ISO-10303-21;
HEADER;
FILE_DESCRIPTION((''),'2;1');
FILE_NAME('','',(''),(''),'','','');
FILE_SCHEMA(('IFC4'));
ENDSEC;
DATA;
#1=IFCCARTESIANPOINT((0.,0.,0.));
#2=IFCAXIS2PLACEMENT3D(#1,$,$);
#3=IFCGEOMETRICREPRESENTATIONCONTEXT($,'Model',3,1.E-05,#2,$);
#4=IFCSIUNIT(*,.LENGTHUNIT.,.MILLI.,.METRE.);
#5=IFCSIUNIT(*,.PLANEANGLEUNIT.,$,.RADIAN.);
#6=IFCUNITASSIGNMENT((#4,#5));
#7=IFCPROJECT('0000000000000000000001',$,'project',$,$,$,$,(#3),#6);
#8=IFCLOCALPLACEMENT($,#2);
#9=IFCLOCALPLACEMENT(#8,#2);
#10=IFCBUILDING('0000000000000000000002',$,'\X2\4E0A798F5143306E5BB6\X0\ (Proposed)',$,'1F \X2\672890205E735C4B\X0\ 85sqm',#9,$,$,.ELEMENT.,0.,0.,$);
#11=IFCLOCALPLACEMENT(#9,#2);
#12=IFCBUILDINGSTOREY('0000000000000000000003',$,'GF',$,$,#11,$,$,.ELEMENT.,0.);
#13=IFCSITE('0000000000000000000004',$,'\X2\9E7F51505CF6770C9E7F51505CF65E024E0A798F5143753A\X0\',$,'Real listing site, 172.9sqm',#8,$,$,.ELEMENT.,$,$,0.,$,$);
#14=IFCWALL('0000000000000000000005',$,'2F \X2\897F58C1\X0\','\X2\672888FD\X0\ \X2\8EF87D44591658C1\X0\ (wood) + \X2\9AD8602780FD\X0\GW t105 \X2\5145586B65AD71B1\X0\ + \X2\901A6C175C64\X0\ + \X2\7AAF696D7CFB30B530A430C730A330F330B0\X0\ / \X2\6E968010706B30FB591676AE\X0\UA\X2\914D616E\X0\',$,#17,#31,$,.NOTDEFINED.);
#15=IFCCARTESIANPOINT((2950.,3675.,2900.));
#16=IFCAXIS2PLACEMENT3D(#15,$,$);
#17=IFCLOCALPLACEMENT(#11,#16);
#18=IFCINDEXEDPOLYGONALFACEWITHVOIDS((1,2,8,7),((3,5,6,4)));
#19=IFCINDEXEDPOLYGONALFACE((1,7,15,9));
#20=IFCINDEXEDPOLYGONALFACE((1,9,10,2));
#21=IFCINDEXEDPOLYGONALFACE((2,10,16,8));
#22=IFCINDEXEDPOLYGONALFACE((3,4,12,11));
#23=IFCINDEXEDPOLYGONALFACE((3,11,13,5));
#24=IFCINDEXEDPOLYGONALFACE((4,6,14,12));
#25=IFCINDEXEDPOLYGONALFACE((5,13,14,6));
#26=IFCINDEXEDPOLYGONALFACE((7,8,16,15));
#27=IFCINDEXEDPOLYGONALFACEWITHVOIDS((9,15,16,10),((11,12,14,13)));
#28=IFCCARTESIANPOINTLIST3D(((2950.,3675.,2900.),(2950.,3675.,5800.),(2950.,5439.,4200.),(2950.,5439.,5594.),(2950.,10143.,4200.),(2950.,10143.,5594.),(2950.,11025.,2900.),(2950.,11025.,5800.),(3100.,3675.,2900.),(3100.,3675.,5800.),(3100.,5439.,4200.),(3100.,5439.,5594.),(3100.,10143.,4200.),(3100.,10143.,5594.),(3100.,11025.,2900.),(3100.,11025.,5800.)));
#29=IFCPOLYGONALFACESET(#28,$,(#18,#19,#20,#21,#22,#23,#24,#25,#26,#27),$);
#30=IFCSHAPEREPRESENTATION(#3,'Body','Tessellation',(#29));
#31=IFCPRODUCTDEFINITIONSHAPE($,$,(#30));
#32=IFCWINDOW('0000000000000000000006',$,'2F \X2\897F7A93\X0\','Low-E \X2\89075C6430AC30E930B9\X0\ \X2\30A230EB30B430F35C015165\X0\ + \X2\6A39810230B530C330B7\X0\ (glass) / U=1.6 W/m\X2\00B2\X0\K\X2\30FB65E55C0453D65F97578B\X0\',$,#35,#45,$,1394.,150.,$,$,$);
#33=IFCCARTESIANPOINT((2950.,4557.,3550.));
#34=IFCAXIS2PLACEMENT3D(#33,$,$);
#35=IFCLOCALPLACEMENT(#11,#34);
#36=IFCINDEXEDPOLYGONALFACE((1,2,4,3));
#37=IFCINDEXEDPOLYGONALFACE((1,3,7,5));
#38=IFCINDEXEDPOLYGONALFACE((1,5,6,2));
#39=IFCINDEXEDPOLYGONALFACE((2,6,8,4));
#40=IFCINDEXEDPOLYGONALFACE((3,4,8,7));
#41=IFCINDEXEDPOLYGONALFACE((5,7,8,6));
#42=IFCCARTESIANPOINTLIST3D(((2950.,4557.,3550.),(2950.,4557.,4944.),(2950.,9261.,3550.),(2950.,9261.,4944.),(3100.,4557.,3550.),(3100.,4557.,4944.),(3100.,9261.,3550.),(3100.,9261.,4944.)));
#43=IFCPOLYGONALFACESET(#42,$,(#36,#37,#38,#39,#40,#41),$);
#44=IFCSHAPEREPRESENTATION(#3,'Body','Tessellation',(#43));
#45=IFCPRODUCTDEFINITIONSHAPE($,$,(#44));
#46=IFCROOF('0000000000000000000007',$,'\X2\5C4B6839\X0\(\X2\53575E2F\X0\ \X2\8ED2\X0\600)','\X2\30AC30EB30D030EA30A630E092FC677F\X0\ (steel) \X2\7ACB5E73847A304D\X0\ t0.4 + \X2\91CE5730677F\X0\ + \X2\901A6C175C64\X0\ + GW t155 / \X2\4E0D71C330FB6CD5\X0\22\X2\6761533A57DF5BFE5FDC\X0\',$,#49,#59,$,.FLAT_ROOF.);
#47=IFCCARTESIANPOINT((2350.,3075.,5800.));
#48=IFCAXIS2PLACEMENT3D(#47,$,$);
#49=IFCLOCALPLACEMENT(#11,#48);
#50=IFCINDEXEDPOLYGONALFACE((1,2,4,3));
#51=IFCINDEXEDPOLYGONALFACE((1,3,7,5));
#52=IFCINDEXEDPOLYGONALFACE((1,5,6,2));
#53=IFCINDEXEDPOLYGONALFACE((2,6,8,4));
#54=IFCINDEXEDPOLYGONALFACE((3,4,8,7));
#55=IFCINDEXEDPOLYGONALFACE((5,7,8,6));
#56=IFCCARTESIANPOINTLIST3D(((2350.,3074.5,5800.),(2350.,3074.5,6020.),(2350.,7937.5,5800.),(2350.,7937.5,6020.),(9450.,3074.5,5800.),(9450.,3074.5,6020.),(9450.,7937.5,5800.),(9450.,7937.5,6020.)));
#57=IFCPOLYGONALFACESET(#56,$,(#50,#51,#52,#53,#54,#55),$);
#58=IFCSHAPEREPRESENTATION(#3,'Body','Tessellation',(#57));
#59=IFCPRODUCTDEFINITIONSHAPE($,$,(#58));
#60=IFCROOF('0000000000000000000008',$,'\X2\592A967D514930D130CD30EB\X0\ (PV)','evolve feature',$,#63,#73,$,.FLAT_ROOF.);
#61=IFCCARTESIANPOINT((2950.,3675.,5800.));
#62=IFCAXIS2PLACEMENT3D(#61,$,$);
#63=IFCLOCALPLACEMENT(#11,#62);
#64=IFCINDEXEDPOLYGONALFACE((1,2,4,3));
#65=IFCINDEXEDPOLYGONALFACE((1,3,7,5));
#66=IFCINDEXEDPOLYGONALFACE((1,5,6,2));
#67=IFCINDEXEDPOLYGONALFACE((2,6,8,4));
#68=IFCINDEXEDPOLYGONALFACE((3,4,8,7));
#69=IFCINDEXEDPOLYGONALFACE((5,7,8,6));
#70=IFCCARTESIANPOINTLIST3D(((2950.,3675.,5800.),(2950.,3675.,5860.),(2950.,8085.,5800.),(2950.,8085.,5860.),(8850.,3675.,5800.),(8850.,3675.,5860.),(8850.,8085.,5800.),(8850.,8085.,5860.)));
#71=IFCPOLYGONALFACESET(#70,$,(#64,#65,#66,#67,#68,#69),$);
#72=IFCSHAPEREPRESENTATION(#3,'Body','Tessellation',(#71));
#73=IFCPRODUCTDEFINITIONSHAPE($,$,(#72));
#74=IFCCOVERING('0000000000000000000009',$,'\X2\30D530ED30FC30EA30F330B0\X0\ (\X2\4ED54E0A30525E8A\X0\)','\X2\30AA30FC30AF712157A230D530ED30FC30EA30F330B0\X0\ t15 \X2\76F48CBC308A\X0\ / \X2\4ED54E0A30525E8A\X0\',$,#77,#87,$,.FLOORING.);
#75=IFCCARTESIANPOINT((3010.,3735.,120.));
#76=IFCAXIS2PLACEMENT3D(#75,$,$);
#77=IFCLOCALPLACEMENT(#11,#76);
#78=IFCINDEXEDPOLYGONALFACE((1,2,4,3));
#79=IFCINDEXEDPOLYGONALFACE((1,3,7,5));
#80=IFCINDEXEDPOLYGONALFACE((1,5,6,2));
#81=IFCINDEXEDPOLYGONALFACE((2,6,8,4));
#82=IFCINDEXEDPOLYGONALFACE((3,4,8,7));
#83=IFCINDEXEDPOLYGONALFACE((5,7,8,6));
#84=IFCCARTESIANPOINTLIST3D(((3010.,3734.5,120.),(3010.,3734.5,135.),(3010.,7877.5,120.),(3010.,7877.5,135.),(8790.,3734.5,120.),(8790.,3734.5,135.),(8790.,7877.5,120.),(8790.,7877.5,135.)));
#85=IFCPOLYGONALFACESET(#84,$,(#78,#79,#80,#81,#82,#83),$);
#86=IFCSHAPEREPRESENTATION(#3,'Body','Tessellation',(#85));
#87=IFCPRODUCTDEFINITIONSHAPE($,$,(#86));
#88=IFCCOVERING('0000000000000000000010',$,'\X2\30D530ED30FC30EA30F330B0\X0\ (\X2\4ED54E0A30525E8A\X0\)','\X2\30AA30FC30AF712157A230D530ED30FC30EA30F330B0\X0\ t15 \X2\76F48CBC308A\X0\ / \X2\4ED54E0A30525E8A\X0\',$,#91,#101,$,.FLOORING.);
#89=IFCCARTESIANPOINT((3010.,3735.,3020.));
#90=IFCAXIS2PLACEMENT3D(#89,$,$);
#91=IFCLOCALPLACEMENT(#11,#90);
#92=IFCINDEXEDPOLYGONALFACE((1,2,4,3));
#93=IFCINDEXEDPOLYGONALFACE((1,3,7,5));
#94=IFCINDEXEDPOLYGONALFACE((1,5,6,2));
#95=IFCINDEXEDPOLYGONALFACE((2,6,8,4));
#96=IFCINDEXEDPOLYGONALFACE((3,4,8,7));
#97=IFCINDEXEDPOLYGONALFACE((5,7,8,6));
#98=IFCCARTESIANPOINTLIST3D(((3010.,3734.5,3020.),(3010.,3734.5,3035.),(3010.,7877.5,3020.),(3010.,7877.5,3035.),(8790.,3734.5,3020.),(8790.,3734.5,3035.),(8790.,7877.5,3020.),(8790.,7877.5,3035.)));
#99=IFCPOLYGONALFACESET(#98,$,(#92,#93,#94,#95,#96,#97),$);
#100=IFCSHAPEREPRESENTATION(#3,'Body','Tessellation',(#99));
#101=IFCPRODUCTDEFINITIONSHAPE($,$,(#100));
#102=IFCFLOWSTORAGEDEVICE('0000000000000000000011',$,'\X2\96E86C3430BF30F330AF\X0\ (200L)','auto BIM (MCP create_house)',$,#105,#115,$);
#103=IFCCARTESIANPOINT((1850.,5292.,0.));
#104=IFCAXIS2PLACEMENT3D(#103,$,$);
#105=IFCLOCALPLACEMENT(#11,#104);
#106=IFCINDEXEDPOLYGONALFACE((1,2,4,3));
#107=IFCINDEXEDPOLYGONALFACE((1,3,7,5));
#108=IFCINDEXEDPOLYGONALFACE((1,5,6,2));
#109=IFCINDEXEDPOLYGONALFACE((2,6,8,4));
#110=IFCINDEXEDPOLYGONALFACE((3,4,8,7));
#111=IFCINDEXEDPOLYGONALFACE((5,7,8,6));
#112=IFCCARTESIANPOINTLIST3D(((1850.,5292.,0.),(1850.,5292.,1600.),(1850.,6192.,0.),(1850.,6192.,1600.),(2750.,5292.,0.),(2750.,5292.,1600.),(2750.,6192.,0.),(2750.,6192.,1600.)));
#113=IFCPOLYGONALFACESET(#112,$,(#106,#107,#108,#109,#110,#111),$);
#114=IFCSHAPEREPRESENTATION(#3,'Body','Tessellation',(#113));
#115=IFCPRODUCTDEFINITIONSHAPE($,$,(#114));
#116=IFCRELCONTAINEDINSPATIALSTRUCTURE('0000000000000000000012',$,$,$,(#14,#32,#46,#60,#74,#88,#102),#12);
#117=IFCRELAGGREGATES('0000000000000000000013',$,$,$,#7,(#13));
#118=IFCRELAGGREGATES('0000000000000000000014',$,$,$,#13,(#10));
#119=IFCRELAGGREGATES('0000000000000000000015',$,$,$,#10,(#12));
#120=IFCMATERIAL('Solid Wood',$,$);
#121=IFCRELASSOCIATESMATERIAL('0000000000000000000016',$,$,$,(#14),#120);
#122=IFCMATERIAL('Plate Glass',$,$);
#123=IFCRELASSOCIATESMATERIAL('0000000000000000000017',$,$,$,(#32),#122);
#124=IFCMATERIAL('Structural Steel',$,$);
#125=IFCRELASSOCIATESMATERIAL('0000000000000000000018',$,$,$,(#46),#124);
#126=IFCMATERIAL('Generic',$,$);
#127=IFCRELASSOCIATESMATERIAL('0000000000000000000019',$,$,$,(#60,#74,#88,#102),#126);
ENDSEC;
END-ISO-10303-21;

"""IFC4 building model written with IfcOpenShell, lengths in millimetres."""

from ifc_helpers import new_model, si_unit, frame, frame_2d, origin, place, context, project, spatial, rectangle, extrude, material, element, fill, save


model = new_model("IFC4")

# Units and contexts
model_context = context("Model", 3, precision=1e-05, world=origin())
ifc_project = project(units=[si_unit("LENGTHUNIT", "METRE", prefix="MILLI"), si_unit("PLANEANGLEUNIT", "RADIAN")], contexts=[model_context])

# Site, building, storey
site_placement = place(None, origin())
site = spatial("IfcSite", under=ifc_project, at=site_placement, Name="鹿児島県鹿児島市上福元町", ObjectType="Real listing site, 172.9sqm", CompositionType="ELEMENT", RefElevation=0.0)
building_placement = place(site_placement, origin())
building = spatial("IfcBuilding", under=site, at=building_placement, Name="上福元の家 (Proposed)", ObjectType="1F 木造平屋 85sqm", CompositionType="ELEMENT", ElevationOfRefHeight=0.0, ElevationOfTerrain=0.0)
storey_placement = place(building_placement, origin())
storey = spatial("IfcBuildingStorey", under=building, at=storey_placement, Name="GF", CompositionType="ELEMENT", Elevation=0.0)

# Shared definitions
ifc_material_1 = material(Name="Solid Wood")
ifc_material_2 = material(Name="Generic")

# Shared definitions
ifc_material_3 = material(Name="Plate Glass")

# Wall, opening, window
wall_1_placement = place(storey_placement, frame((2950.0, 3675.0, 2900.0)))
wall_1 = element("IfcWall", 1, at=wall_1_placement, inside=storey, material=ifc_material_1, Name="2F 西壁", Description="木製 軸組外壁 (wood) + 高性能GW t105 充填断熱 + 通気層 + 窯業系サイディング / 準耐火・外皮UA配慮", PredefinedType="NOTDEFINED", context=model_context, shape_type="SweptSolid", body=[
    extrude(rectangle(XDim=150.0, YDim=7350.0, at=frame_2d((75.0, 3675.0))), frame((2950.0, 3675.0, 2900.0)), (0.0, 0.0, 1.0), 2900.0),
])
opening_1_placement = place(storey_placement, frame((2950.0, 4557.0, 3550.0)))
opening_1 = element("IfcOpeningElement", 2, at=opening_1_placement, cuts=wall_1, PredefinedType="NOTDEFINED", context=model_context, shape_type="SweptSolid", body=[
    extrude(rectangle(XDim=150.0, YDim=4704.0, at=frame_2d((75.0, 2352.0))), frame((2950.0, 4557.0, 3550.0)), (0.0, 0.0, 1.0), 1394.0),
])
window_1_placement = place(storey_placement, frame((2950.0, 4557.0, 3550.0)))
window_1 = element("IfcWindow", 3, at=window_1_placement, inside=storey, material=ifc_material_3, Name="2F 西窓", Description="Low-E 複層ガラス アルゴン封入 + 樹脂サッシ (glass) / U=1.6 W/m²K・日射取得型", OverallHeight=1394.0, OverallWidth=150.0, context=model_context, shape_type="SweptSolid", body=[
    extrude(rectangle(XDim=150.0, YDim=4704.0, at=frame_2d((75.0, 2352.0))), frame((2950.0, 4557.0, 3550.0)), (0.0, 0.0, 1.0), 1394.0),
])
fill(opening_1, window_1)

# Roofs
ifc_material_4 = material(Name="Structural Steel")
for number, where, name in (
    (4, (2350.0, 3075.0, 5800.0), "屋根(南帯 軒600)"),
):
    element("IfcRoof", number, at=place(storey_placement, frame(where)), inside=storey, material=ifc_material_4, Name=name, Description="ガルバリウム鋼板 (steel) 立平葺き t0.4 + 野地板 + 通気層 + GW t155 / 不燃・法22条区域対応", PredefinedType="FLAT_ROOF", context=model_context, shape_type="SweptSolid", body=[
        extrude(rectangle(XDim=7100.0, YDim=4863.0, at=frame_2d((3550.0, 2431.0))), frame((2350.0, 3075.0, 5800.0)), (0.0, 0.0, 1.0), 220.0),
    ])
roof_placement = place(storey_placement, frame((2950.0, 3675.0, 5800.0)))
element("IfcRoof", 5, at=roof_placement, inside=storey, material=ifc_material_2, Name="太陽光パネル (PV)", Description="evolve feature", PredefinedType="FLAT_ROOF", context=model_context, shape_type="SweptSolid", body=[
    extrude(rectangle(XDim=5900.0, YDim=4410.0, at=frame_2d((2950.0, 2205.0))), frame((2950.0, 3675.0, 5800.0)), (0.0, 0.0, 1.0), 60.0),
])

# Coverings
covering_1_placement = place(storey_placement, frame((3010.0, 3735.0, 120.0)))
element("IfcCovering", 6, at=covering_1_placement, inside=storey, material=ifc_material_2, Name="フローリング (仕上げ床)", Description="オーク無垢フローリング t15 直貼り / 仕上げ床", PredefinedType="FLOORING", context=model_context, shape_type="SweptSolid", body=[
    extrude(rectangle(XDim=5780.0, YDim=4143.0, at=frame_2d((2890.0, 2071.0))), frame((3010.0, 3735.0, 120.0)), (0.0, 0.0, 1.0), 15.0),
])
covering_2_placement = place(storey_placement, frame((3010.0, 3735.0, 3020.0)))
element("IfcCovering", 7, at=covering_2_placement, inside=storey, material=ifc_material_2, Name="フローリング (仕上げ床)", Description="オーク無垢フローリング t15 直貼り / 仕上げ床", PredefinedType="FLOORING", context=model_context, shape_type="SweptSolid", body=[
    extrude(rectangle(XDim=5780.0, YDim=4143.0, at=frame_2d((2890.0, 2071.0))), frame((3010.0, 3735.0, 3020.0)), (0.0, 0.0, 1.0), 15.0),
])

# Flow storage device
flow_storage_device_placement = place(storey_placement, frame((1850.0, 5292.0, 0.0)))
element("IfcFlowStorageDevice", 8, at=flow_storage_device_placement, inside=storey, material=ifc_material_2, Name="雨水タンク (200L)", Description="auto BIM (MCP create_house)", context=model_context, shape_type="SweptSolid", body=[
    extrude(rectangle(XDim=900.0, YDim=900.0, at=frame_2d((450.0, 450.0))), frame((1850.0, 5292.0, 0.0)), (0.0, 0.0, 1.0), 1600.0),
])

save(model, "model.ifc")
